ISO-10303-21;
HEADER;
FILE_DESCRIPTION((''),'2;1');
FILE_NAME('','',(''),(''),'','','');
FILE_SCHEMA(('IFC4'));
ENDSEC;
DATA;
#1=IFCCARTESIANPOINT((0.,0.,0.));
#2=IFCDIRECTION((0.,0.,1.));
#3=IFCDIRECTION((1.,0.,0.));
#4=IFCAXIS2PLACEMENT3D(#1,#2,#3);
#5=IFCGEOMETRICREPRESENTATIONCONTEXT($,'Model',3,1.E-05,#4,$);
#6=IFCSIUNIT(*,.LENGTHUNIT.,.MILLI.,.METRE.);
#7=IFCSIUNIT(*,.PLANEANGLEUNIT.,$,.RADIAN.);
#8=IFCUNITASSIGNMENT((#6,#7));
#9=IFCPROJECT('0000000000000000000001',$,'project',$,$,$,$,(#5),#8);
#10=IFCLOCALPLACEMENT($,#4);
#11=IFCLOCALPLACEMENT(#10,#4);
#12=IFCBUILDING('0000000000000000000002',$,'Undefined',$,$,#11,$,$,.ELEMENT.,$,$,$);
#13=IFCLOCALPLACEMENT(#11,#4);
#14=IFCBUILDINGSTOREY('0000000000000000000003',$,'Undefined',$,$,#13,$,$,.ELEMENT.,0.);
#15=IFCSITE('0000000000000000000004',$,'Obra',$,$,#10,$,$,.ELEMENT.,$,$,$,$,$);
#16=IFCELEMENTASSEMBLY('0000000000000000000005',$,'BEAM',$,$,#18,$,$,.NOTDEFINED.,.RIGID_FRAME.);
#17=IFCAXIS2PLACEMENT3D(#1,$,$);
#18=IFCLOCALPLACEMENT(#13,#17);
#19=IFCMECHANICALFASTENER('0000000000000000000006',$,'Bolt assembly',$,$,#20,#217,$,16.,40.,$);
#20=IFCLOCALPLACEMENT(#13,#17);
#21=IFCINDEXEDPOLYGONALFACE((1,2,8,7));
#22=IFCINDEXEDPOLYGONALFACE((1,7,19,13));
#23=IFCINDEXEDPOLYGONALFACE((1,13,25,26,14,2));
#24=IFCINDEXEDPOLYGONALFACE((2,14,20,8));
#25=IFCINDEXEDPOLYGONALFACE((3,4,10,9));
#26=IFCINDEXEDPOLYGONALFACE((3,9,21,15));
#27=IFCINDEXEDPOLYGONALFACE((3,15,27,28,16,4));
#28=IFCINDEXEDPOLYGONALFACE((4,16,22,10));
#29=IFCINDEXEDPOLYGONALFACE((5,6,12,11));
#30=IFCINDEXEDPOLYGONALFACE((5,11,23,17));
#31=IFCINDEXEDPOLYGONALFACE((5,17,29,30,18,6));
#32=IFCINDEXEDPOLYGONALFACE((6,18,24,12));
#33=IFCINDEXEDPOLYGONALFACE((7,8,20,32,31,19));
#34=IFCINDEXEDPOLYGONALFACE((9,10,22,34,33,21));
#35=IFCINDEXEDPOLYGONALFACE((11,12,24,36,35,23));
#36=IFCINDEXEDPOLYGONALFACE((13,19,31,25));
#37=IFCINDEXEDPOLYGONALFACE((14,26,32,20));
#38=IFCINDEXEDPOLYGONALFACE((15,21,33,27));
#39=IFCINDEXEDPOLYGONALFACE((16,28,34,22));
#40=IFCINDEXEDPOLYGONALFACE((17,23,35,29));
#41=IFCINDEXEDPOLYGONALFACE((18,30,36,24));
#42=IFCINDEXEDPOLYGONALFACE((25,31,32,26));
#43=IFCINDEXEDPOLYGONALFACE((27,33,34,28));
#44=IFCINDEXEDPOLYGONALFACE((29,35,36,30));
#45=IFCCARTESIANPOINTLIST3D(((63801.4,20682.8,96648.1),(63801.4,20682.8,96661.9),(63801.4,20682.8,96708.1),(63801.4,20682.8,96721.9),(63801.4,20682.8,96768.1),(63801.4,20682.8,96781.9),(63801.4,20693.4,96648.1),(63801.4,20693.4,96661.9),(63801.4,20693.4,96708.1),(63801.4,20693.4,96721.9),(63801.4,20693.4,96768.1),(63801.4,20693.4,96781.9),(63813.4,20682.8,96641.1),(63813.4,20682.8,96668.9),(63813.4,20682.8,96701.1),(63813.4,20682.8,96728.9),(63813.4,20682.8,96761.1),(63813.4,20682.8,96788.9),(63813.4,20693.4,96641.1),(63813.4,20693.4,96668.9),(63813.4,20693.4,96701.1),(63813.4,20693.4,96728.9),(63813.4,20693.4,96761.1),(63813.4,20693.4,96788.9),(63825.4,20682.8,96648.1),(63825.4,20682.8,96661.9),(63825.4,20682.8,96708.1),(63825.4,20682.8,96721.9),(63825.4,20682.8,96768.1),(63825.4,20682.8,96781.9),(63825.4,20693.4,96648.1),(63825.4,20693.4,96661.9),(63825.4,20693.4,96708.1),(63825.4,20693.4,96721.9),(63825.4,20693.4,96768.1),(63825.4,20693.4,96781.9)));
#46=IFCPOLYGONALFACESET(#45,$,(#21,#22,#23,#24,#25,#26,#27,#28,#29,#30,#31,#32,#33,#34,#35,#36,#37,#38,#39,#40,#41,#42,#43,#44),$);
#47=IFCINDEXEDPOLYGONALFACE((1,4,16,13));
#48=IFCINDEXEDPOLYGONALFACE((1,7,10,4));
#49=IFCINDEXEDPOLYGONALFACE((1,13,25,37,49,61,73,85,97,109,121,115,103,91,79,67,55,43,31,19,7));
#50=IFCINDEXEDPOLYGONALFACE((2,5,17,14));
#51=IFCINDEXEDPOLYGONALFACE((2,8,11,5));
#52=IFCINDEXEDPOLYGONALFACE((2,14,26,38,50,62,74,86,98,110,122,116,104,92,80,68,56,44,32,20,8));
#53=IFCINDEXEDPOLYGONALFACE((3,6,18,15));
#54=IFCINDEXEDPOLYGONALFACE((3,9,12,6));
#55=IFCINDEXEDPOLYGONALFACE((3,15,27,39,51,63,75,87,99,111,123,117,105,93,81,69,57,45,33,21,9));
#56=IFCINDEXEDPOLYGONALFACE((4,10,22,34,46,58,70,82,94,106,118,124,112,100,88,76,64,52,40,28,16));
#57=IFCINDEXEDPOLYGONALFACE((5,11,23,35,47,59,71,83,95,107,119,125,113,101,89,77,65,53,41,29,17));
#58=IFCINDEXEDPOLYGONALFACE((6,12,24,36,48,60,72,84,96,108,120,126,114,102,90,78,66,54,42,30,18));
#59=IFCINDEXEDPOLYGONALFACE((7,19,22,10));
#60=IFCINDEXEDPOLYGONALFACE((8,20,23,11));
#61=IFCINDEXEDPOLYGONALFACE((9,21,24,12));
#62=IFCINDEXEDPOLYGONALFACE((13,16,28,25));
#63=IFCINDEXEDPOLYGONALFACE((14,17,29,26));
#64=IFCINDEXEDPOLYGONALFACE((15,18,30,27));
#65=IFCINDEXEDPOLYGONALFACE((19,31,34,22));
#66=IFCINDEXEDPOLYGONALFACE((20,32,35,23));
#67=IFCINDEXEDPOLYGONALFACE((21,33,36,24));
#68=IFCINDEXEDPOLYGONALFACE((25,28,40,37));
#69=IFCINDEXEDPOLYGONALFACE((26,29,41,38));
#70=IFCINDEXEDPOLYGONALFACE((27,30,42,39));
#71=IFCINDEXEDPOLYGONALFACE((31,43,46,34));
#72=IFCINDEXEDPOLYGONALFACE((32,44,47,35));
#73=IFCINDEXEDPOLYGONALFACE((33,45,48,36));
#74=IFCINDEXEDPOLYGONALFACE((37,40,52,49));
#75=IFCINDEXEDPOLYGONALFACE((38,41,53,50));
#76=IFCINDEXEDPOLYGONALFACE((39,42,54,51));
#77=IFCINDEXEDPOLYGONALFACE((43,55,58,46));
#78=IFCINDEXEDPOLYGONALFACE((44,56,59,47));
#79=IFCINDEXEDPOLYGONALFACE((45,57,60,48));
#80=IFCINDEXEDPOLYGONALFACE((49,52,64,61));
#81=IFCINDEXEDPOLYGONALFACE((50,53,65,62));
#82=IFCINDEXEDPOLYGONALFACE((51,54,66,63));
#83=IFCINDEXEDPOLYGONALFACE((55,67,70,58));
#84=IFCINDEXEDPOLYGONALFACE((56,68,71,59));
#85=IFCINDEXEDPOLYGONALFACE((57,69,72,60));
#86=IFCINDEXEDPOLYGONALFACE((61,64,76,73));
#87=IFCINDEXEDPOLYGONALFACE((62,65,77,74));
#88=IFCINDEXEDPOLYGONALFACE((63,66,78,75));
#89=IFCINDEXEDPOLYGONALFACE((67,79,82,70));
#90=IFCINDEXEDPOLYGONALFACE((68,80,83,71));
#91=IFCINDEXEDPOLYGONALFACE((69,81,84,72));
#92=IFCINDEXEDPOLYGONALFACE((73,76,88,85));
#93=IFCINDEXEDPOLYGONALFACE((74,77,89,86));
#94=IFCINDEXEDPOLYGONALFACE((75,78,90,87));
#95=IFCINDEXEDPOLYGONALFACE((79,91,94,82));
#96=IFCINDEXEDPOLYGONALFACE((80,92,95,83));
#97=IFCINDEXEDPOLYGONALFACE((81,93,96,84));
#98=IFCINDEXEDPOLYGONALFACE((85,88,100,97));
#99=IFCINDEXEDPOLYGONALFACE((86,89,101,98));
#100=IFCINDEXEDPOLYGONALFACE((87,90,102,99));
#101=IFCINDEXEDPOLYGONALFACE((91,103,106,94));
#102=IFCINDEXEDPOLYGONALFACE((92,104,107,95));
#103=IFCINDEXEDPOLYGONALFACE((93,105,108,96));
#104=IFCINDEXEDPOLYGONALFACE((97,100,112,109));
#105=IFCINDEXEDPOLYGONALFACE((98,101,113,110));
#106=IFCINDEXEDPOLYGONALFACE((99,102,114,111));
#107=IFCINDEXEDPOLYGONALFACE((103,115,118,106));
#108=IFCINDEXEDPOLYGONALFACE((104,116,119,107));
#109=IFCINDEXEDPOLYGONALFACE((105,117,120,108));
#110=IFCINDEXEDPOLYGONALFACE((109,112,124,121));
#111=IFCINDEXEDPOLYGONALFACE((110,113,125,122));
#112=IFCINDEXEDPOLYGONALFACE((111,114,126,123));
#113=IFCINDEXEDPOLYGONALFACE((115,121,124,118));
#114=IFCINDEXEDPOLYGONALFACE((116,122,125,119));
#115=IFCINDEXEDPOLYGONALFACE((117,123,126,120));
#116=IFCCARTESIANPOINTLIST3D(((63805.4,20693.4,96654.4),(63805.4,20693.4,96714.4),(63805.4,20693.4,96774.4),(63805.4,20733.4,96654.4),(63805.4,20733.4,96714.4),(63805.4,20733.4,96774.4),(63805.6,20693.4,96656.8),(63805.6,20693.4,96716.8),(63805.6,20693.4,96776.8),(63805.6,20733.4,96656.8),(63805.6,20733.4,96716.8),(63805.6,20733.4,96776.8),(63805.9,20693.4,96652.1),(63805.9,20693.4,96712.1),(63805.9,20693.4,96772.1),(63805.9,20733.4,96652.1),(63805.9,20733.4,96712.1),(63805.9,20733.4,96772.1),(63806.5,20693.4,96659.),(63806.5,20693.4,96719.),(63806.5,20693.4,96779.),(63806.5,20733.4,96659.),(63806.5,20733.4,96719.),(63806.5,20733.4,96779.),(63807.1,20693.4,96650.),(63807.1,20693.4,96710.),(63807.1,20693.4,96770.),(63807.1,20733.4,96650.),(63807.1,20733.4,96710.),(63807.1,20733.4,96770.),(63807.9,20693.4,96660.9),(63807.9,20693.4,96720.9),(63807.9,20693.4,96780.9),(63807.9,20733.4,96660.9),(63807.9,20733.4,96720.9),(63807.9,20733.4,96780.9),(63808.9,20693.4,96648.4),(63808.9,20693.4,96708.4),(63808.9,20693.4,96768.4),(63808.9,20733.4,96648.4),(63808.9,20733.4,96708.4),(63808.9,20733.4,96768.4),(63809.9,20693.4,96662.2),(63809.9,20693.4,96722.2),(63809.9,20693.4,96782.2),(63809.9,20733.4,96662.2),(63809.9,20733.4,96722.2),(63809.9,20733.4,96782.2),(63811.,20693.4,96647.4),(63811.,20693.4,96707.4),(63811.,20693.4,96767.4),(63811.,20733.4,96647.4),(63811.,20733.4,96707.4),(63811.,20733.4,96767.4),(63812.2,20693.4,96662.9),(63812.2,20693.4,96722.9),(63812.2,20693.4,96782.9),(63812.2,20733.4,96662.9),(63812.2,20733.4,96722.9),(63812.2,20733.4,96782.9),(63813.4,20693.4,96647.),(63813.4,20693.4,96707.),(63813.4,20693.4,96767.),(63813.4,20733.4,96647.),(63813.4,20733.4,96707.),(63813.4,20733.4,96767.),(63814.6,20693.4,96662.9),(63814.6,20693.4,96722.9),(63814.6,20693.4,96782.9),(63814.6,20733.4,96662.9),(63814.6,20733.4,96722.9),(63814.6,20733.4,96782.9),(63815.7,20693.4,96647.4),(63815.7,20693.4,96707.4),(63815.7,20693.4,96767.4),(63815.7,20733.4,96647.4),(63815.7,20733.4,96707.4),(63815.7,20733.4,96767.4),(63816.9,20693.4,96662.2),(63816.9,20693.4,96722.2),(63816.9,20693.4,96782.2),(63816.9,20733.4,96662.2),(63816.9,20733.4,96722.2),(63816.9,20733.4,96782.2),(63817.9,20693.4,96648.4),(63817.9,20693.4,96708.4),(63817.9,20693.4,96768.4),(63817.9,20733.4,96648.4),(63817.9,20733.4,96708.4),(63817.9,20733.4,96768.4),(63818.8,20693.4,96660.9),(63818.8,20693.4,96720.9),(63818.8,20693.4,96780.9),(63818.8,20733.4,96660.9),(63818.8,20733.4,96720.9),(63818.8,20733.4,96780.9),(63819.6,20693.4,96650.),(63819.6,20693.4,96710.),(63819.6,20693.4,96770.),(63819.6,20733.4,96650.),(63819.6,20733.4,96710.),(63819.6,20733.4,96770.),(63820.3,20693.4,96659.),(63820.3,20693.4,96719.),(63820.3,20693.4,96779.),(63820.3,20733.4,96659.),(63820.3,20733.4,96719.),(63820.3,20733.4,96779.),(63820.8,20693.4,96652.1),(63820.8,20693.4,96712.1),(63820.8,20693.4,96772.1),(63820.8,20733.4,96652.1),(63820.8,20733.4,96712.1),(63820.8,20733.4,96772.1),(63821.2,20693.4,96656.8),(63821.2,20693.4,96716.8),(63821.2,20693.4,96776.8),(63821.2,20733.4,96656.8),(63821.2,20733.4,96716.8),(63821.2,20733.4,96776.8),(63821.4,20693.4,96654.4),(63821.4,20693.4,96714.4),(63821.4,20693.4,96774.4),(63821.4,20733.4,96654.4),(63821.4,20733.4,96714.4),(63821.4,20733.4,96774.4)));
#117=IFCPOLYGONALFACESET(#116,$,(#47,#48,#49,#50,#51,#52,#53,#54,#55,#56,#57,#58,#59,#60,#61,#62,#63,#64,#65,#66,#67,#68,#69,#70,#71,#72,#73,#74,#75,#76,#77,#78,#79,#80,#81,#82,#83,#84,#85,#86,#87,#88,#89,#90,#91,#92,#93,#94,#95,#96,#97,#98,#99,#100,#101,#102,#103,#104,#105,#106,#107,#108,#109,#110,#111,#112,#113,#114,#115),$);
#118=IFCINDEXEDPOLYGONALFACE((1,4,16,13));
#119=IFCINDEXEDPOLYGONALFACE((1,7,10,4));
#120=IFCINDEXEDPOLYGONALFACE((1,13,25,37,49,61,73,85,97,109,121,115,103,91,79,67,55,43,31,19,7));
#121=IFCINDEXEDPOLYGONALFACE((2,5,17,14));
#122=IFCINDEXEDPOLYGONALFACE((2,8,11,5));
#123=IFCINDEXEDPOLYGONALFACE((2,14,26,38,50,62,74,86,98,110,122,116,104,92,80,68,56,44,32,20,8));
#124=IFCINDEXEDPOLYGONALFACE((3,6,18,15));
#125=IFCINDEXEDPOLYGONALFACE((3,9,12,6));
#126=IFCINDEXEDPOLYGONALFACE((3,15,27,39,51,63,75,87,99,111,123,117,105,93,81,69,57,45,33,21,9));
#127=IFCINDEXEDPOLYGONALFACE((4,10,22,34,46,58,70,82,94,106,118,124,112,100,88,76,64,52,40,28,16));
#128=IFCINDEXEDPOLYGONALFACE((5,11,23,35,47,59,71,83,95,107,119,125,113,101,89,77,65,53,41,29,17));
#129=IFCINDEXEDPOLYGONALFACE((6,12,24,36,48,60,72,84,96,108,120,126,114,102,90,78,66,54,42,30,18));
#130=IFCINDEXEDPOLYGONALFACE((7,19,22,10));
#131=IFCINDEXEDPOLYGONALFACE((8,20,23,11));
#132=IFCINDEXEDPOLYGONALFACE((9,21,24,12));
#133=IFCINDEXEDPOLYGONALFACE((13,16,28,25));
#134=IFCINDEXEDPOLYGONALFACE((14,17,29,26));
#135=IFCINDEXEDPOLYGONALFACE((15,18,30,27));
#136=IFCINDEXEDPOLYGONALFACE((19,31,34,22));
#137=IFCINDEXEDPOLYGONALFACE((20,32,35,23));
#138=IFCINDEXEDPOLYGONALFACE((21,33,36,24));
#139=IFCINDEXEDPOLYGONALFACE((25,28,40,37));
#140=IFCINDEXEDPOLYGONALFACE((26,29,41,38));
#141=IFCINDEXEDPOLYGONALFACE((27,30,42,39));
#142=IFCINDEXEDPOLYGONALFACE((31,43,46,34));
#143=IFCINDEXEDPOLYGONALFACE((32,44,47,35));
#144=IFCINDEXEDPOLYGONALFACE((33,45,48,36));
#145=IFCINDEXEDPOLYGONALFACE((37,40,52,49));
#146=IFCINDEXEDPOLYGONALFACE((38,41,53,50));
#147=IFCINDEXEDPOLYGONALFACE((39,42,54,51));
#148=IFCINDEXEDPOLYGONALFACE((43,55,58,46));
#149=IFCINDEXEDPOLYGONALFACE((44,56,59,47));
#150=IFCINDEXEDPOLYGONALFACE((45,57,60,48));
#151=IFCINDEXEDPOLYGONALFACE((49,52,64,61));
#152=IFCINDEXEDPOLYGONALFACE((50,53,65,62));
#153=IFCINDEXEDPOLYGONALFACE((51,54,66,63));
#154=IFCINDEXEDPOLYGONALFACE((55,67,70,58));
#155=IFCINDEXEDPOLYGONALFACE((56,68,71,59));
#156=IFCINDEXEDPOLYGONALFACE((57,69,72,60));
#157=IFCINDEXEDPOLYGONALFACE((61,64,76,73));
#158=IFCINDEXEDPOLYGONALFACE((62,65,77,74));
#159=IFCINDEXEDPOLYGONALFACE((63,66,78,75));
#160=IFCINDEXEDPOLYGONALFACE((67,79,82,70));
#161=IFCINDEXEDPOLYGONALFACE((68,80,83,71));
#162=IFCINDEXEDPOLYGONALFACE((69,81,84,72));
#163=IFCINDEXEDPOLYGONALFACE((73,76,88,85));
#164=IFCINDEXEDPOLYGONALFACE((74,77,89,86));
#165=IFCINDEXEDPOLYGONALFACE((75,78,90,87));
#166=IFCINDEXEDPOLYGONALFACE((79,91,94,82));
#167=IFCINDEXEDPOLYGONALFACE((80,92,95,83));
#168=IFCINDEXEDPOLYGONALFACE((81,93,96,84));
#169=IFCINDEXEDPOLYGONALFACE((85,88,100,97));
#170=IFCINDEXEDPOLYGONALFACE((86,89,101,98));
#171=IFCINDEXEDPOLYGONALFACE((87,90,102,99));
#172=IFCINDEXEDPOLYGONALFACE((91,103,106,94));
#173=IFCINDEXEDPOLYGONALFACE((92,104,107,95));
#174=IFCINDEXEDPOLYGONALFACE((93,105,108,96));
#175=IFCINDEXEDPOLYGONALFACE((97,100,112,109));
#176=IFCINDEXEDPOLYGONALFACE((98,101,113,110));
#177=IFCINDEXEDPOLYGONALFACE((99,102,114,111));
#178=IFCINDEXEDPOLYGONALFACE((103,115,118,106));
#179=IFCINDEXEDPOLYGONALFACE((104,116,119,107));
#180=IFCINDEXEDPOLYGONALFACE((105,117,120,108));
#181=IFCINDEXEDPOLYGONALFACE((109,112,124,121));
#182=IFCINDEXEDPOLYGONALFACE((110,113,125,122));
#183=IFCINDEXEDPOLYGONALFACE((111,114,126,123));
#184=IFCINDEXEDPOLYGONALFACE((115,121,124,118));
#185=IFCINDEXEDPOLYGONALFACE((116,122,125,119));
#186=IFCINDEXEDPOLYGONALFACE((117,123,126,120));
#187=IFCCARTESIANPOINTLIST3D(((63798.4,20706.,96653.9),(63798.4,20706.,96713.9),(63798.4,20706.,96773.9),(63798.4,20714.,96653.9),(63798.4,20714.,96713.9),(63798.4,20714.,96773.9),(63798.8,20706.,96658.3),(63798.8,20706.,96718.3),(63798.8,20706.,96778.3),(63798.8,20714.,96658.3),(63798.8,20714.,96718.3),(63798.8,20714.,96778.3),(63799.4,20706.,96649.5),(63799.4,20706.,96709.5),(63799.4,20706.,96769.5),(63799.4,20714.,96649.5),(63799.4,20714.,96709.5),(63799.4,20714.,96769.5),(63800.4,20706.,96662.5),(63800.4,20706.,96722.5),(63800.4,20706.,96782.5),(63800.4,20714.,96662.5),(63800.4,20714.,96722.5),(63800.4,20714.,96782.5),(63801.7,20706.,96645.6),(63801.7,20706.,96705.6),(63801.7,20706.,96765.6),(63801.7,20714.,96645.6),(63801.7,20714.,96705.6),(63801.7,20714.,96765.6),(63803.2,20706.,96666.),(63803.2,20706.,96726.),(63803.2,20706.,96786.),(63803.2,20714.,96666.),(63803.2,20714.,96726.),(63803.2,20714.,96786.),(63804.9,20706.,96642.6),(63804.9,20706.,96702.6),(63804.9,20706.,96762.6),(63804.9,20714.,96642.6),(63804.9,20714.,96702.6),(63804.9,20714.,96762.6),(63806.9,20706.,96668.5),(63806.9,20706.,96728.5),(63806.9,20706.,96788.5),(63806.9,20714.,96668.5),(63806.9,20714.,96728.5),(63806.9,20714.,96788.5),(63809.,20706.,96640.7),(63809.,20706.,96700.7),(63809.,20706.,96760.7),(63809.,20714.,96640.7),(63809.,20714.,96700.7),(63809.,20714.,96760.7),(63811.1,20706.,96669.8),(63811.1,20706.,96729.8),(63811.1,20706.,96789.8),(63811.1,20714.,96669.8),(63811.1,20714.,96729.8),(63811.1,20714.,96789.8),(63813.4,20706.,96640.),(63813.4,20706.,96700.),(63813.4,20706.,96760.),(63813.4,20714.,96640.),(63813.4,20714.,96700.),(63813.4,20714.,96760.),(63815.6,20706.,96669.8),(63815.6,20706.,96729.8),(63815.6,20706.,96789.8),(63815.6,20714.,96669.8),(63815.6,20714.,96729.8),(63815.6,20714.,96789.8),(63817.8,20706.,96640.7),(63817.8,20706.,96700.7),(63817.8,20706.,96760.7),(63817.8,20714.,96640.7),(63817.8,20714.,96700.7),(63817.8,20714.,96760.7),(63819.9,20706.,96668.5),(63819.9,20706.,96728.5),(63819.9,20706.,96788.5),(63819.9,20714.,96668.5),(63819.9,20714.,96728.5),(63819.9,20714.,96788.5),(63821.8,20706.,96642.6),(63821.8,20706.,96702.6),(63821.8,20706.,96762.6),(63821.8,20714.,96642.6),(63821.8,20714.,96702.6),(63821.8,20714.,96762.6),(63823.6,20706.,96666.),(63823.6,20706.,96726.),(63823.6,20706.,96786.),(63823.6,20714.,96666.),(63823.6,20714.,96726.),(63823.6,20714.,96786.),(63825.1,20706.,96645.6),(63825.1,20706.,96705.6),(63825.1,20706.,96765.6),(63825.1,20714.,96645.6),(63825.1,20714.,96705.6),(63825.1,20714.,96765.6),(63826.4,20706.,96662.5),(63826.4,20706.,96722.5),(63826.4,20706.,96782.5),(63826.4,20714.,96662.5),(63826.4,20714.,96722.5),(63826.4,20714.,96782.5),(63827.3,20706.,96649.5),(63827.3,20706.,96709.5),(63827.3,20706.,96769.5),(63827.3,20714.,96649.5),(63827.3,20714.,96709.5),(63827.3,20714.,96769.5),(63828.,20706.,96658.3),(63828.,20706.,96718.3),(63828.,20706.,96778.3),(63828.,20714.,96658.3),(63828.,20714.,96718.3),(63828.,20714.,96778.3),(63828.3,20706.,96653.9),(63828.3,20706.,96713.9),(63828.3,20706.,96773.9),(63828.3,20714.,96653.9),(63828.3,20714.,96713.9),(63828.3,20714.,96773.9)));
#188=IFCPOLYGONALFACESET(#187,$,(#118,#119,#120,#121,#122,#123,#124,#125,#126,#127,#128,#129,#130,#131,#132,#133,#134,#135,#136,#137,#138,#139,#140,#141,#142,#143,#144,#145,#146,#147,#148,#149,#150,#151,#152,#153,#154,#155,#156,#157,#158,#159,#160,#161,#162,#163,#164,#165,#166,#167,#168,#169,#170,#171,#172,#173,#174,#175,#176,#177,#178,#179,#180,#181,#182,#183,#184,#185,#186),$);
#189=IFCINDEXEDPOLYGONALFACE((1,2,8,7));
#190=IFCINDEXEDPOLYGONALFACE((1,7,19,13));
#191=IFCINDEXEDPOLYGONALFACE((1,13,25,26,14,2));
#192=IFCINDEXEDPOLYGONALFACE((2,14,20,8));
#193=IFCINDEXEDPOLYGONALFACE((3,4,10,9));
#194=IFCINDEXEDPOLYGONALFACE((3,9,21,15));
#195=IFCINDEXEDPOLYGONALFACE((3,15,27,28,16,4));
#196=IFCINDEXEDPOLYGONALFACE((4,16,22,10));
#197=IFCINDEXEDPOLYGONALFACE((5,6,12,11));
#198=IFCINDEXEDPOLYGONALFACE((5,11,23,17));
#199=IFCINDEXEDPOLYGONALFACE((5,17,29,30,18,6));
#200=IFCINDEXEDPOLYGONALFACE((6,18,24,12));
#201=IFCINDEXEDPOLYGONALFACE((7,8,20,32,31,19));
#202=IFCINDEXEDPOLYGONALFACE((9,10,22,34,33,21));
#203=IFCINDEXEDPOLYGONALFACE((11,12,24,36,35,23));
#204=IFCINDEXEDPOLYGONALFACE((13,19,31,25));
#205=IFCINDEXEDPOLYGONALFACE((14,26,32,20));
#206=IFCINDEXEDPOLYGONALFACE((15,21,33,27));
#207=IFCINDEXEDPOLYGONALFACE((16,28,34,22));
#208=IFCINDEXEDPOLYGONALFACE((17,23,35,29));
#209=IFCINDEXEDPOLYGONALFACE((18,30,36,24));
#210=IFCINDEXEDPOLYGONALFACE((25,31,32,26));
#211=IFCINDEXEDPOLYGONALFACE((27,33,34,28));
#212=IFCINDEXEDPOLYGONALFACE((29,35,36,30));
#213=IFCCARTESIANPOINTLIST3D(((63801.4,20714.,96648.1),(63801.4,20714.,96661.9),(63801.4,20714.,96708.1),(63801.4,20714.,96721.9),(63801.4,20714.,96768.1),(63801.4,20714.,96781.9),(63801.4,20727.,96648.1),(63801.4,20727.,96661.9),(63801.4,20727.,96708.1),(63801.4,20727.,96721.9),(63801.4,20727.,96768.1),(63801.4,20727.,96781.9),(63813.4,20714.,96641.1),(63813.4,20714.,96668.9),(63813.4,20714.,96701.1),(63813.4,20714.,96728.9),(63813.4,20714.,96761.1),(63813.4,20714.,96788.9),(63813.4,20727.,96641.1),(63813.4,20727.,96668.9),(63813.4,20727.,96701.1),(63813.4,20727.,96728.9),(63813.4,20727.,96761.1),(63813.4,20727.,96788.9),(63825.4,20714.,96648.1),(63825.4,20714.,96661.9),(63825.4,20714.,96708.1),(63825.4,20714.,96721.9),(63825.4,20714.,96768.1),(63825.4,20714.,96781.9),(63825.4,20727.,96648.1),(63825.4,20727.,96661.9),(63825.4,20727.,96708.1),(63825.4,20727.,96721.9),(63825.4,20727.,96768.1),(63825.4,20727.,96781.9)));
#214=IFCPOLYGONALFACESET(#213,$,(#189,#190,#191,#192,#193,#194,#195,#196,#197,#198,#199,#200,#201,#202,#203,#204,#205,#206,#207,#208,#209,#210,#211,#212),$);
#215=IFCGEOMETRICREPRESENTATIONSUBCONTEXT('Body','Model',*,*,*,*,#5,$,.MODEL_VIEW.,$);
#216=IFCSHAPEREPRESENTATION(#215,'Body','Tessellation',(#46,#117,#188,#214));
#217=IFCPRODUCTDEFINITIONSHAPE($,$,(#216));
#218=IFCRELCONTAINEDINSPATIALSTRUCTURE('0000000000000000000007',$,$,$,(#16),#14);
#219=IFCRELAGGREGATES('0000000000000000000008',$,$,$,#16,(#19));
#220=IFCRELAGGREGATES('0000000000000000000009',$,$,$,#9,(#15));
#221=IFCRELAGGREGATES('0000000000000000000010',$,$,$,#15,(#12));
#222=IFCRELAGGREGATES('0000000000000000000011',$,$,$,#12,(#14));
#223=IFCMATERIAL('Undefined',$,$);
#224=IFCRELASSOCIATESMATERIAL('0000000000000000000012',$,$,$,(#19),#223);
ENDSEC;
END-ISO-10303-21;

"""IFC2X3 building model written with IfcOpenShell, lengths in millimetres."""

from ifc_helpers import new_model, si_unit, frame, origin_with_axes, origin_2d_with_axis, place, context, subcontext, project, spatial, polyline, circle, outline, extrude, source, transform, mapped, material, element, aggregate, save


model = new_model("IFC2X3")

# Units and contexts
model_context = context("Model", 3, precision=1e-05, world=origin_with_axes())
body_context = subcontext(model_context, "Body", "Model", "MODEL_VIEW")
ifc_project = project(units=[si_unit("LENGTHUNIT", "METRE", prefix="MILLI"), si_unit("PLANEANGLEUNIT", "RADIAN")], contexts=[model_context])

# Site, building, storey
site_placement = place(None, origin_with_axes())
site = spatial("IfcSite", under=ifc_project, at=site_placement, Name="Obra", CompositionType="ELEMENT")
building_placement = place(site_placement, origin_with_axes())
building = spatial("IfcBuilding", under=site, at=building_placement, Name="Undefined", CompositionType="ELEMENT")
storey_placement = place(building_placement, origin_with_axes())
storey = spatial("IfcBuildingStorey", under=building, at=storey_placement, Name="Undefined", CompositionType="ELEMENT", Elevation=0.0)

# Shared definitions
ifc_material_1 = material(Name="Undefined")

# Element assembly, mechanical fastener
shared_shape_1 = source(origin_with_axes(), body_context, "Body", "SweptSolid", [
    extrude(outline(polyline([(13.9, 0.0), (6.9, 12.0), (-6.9, 12.0), (-13.9, 0.0), (-6.9, -12.0), (6.9, -12.0), (13.9, 0.0)])), frame((0.0, -19.9, 0.0), z_axis=(0.0, 1.0, 0.0), x_axis=(1.0, 0.0, 0.0)), (0.0, 0.0, 1.0), 10.6),
    extrude(circle(Radius=8.0, at=origin_2d_with_axis()), frame((0.0, -9.3, 0.0), z_axis=(0.0, 1.0, 0.0), x_axis=(1.0, 0.0, 0.0)), (0.0, 0.0, 1.0), 40.0),
    extrude(circle(Radius=15.0, at=origin_2d_with_axis()), frame((0.0, 3.3, 0.0), z_axis=(0.0, 1.0, 0.0), x_axis=(1.0, 0.0, 0.0)), (0.0, 0.0, 1.0), 8.0),
    extrude(outline(polyline([(13.9, 0.0), (6.9, 12.0), (-6.9, 12.0), (-13.9, 0.0), (-6.9, -12.0), (6.9, -12.0), (13.9, 0.0)])), frame((0.0, 11.3, 0.0), z_axis=(0.0, 1.0, 0.0), x_axis=(1.0, 0.0, 0.0)), (0.0, 0.0, 1.0), 13.0),
])
assembly_1_placement = place(storey_placement, origin_with_axes())
assembly_1 = element("IfcElementAssembly", 1, at=assembly_1_placement, inside=storey, Name="BEAM", AssemblyPlace="NOTDEFINED", PredefinedType="RIGID_FRAME")
mechanical_fastener_1_placement = place(assembly_1_placement, frame((63763.4, 20702.7, 96850.0), z_axis=(1.0, 0.0, 0.0), x_axis=(0.0, 0.0, -1.0)))
mechanical_fastener_1 = element("IfcMechanicalFastener", 2, at=mechanical_fastener_1_placement, material=ifc_material_1, Name="Bolt assembly", NominalDiameter=16.0, NominalLength=40.0, context=body_context, shape_type="MappedRepresentation", body=[
    mapped(shared_shape_1, transform((75.0, 0.0, 50.0))),
    mapped(shared_shape_1, transform((135.0, 0.0, 50.0))),
    mapped(shared_shape_1, transform((195.0, 0.0, 50.0))),
])
aggregate(assembly_1, [mechanical_fastener_1])

save(model, "model.ifc")
